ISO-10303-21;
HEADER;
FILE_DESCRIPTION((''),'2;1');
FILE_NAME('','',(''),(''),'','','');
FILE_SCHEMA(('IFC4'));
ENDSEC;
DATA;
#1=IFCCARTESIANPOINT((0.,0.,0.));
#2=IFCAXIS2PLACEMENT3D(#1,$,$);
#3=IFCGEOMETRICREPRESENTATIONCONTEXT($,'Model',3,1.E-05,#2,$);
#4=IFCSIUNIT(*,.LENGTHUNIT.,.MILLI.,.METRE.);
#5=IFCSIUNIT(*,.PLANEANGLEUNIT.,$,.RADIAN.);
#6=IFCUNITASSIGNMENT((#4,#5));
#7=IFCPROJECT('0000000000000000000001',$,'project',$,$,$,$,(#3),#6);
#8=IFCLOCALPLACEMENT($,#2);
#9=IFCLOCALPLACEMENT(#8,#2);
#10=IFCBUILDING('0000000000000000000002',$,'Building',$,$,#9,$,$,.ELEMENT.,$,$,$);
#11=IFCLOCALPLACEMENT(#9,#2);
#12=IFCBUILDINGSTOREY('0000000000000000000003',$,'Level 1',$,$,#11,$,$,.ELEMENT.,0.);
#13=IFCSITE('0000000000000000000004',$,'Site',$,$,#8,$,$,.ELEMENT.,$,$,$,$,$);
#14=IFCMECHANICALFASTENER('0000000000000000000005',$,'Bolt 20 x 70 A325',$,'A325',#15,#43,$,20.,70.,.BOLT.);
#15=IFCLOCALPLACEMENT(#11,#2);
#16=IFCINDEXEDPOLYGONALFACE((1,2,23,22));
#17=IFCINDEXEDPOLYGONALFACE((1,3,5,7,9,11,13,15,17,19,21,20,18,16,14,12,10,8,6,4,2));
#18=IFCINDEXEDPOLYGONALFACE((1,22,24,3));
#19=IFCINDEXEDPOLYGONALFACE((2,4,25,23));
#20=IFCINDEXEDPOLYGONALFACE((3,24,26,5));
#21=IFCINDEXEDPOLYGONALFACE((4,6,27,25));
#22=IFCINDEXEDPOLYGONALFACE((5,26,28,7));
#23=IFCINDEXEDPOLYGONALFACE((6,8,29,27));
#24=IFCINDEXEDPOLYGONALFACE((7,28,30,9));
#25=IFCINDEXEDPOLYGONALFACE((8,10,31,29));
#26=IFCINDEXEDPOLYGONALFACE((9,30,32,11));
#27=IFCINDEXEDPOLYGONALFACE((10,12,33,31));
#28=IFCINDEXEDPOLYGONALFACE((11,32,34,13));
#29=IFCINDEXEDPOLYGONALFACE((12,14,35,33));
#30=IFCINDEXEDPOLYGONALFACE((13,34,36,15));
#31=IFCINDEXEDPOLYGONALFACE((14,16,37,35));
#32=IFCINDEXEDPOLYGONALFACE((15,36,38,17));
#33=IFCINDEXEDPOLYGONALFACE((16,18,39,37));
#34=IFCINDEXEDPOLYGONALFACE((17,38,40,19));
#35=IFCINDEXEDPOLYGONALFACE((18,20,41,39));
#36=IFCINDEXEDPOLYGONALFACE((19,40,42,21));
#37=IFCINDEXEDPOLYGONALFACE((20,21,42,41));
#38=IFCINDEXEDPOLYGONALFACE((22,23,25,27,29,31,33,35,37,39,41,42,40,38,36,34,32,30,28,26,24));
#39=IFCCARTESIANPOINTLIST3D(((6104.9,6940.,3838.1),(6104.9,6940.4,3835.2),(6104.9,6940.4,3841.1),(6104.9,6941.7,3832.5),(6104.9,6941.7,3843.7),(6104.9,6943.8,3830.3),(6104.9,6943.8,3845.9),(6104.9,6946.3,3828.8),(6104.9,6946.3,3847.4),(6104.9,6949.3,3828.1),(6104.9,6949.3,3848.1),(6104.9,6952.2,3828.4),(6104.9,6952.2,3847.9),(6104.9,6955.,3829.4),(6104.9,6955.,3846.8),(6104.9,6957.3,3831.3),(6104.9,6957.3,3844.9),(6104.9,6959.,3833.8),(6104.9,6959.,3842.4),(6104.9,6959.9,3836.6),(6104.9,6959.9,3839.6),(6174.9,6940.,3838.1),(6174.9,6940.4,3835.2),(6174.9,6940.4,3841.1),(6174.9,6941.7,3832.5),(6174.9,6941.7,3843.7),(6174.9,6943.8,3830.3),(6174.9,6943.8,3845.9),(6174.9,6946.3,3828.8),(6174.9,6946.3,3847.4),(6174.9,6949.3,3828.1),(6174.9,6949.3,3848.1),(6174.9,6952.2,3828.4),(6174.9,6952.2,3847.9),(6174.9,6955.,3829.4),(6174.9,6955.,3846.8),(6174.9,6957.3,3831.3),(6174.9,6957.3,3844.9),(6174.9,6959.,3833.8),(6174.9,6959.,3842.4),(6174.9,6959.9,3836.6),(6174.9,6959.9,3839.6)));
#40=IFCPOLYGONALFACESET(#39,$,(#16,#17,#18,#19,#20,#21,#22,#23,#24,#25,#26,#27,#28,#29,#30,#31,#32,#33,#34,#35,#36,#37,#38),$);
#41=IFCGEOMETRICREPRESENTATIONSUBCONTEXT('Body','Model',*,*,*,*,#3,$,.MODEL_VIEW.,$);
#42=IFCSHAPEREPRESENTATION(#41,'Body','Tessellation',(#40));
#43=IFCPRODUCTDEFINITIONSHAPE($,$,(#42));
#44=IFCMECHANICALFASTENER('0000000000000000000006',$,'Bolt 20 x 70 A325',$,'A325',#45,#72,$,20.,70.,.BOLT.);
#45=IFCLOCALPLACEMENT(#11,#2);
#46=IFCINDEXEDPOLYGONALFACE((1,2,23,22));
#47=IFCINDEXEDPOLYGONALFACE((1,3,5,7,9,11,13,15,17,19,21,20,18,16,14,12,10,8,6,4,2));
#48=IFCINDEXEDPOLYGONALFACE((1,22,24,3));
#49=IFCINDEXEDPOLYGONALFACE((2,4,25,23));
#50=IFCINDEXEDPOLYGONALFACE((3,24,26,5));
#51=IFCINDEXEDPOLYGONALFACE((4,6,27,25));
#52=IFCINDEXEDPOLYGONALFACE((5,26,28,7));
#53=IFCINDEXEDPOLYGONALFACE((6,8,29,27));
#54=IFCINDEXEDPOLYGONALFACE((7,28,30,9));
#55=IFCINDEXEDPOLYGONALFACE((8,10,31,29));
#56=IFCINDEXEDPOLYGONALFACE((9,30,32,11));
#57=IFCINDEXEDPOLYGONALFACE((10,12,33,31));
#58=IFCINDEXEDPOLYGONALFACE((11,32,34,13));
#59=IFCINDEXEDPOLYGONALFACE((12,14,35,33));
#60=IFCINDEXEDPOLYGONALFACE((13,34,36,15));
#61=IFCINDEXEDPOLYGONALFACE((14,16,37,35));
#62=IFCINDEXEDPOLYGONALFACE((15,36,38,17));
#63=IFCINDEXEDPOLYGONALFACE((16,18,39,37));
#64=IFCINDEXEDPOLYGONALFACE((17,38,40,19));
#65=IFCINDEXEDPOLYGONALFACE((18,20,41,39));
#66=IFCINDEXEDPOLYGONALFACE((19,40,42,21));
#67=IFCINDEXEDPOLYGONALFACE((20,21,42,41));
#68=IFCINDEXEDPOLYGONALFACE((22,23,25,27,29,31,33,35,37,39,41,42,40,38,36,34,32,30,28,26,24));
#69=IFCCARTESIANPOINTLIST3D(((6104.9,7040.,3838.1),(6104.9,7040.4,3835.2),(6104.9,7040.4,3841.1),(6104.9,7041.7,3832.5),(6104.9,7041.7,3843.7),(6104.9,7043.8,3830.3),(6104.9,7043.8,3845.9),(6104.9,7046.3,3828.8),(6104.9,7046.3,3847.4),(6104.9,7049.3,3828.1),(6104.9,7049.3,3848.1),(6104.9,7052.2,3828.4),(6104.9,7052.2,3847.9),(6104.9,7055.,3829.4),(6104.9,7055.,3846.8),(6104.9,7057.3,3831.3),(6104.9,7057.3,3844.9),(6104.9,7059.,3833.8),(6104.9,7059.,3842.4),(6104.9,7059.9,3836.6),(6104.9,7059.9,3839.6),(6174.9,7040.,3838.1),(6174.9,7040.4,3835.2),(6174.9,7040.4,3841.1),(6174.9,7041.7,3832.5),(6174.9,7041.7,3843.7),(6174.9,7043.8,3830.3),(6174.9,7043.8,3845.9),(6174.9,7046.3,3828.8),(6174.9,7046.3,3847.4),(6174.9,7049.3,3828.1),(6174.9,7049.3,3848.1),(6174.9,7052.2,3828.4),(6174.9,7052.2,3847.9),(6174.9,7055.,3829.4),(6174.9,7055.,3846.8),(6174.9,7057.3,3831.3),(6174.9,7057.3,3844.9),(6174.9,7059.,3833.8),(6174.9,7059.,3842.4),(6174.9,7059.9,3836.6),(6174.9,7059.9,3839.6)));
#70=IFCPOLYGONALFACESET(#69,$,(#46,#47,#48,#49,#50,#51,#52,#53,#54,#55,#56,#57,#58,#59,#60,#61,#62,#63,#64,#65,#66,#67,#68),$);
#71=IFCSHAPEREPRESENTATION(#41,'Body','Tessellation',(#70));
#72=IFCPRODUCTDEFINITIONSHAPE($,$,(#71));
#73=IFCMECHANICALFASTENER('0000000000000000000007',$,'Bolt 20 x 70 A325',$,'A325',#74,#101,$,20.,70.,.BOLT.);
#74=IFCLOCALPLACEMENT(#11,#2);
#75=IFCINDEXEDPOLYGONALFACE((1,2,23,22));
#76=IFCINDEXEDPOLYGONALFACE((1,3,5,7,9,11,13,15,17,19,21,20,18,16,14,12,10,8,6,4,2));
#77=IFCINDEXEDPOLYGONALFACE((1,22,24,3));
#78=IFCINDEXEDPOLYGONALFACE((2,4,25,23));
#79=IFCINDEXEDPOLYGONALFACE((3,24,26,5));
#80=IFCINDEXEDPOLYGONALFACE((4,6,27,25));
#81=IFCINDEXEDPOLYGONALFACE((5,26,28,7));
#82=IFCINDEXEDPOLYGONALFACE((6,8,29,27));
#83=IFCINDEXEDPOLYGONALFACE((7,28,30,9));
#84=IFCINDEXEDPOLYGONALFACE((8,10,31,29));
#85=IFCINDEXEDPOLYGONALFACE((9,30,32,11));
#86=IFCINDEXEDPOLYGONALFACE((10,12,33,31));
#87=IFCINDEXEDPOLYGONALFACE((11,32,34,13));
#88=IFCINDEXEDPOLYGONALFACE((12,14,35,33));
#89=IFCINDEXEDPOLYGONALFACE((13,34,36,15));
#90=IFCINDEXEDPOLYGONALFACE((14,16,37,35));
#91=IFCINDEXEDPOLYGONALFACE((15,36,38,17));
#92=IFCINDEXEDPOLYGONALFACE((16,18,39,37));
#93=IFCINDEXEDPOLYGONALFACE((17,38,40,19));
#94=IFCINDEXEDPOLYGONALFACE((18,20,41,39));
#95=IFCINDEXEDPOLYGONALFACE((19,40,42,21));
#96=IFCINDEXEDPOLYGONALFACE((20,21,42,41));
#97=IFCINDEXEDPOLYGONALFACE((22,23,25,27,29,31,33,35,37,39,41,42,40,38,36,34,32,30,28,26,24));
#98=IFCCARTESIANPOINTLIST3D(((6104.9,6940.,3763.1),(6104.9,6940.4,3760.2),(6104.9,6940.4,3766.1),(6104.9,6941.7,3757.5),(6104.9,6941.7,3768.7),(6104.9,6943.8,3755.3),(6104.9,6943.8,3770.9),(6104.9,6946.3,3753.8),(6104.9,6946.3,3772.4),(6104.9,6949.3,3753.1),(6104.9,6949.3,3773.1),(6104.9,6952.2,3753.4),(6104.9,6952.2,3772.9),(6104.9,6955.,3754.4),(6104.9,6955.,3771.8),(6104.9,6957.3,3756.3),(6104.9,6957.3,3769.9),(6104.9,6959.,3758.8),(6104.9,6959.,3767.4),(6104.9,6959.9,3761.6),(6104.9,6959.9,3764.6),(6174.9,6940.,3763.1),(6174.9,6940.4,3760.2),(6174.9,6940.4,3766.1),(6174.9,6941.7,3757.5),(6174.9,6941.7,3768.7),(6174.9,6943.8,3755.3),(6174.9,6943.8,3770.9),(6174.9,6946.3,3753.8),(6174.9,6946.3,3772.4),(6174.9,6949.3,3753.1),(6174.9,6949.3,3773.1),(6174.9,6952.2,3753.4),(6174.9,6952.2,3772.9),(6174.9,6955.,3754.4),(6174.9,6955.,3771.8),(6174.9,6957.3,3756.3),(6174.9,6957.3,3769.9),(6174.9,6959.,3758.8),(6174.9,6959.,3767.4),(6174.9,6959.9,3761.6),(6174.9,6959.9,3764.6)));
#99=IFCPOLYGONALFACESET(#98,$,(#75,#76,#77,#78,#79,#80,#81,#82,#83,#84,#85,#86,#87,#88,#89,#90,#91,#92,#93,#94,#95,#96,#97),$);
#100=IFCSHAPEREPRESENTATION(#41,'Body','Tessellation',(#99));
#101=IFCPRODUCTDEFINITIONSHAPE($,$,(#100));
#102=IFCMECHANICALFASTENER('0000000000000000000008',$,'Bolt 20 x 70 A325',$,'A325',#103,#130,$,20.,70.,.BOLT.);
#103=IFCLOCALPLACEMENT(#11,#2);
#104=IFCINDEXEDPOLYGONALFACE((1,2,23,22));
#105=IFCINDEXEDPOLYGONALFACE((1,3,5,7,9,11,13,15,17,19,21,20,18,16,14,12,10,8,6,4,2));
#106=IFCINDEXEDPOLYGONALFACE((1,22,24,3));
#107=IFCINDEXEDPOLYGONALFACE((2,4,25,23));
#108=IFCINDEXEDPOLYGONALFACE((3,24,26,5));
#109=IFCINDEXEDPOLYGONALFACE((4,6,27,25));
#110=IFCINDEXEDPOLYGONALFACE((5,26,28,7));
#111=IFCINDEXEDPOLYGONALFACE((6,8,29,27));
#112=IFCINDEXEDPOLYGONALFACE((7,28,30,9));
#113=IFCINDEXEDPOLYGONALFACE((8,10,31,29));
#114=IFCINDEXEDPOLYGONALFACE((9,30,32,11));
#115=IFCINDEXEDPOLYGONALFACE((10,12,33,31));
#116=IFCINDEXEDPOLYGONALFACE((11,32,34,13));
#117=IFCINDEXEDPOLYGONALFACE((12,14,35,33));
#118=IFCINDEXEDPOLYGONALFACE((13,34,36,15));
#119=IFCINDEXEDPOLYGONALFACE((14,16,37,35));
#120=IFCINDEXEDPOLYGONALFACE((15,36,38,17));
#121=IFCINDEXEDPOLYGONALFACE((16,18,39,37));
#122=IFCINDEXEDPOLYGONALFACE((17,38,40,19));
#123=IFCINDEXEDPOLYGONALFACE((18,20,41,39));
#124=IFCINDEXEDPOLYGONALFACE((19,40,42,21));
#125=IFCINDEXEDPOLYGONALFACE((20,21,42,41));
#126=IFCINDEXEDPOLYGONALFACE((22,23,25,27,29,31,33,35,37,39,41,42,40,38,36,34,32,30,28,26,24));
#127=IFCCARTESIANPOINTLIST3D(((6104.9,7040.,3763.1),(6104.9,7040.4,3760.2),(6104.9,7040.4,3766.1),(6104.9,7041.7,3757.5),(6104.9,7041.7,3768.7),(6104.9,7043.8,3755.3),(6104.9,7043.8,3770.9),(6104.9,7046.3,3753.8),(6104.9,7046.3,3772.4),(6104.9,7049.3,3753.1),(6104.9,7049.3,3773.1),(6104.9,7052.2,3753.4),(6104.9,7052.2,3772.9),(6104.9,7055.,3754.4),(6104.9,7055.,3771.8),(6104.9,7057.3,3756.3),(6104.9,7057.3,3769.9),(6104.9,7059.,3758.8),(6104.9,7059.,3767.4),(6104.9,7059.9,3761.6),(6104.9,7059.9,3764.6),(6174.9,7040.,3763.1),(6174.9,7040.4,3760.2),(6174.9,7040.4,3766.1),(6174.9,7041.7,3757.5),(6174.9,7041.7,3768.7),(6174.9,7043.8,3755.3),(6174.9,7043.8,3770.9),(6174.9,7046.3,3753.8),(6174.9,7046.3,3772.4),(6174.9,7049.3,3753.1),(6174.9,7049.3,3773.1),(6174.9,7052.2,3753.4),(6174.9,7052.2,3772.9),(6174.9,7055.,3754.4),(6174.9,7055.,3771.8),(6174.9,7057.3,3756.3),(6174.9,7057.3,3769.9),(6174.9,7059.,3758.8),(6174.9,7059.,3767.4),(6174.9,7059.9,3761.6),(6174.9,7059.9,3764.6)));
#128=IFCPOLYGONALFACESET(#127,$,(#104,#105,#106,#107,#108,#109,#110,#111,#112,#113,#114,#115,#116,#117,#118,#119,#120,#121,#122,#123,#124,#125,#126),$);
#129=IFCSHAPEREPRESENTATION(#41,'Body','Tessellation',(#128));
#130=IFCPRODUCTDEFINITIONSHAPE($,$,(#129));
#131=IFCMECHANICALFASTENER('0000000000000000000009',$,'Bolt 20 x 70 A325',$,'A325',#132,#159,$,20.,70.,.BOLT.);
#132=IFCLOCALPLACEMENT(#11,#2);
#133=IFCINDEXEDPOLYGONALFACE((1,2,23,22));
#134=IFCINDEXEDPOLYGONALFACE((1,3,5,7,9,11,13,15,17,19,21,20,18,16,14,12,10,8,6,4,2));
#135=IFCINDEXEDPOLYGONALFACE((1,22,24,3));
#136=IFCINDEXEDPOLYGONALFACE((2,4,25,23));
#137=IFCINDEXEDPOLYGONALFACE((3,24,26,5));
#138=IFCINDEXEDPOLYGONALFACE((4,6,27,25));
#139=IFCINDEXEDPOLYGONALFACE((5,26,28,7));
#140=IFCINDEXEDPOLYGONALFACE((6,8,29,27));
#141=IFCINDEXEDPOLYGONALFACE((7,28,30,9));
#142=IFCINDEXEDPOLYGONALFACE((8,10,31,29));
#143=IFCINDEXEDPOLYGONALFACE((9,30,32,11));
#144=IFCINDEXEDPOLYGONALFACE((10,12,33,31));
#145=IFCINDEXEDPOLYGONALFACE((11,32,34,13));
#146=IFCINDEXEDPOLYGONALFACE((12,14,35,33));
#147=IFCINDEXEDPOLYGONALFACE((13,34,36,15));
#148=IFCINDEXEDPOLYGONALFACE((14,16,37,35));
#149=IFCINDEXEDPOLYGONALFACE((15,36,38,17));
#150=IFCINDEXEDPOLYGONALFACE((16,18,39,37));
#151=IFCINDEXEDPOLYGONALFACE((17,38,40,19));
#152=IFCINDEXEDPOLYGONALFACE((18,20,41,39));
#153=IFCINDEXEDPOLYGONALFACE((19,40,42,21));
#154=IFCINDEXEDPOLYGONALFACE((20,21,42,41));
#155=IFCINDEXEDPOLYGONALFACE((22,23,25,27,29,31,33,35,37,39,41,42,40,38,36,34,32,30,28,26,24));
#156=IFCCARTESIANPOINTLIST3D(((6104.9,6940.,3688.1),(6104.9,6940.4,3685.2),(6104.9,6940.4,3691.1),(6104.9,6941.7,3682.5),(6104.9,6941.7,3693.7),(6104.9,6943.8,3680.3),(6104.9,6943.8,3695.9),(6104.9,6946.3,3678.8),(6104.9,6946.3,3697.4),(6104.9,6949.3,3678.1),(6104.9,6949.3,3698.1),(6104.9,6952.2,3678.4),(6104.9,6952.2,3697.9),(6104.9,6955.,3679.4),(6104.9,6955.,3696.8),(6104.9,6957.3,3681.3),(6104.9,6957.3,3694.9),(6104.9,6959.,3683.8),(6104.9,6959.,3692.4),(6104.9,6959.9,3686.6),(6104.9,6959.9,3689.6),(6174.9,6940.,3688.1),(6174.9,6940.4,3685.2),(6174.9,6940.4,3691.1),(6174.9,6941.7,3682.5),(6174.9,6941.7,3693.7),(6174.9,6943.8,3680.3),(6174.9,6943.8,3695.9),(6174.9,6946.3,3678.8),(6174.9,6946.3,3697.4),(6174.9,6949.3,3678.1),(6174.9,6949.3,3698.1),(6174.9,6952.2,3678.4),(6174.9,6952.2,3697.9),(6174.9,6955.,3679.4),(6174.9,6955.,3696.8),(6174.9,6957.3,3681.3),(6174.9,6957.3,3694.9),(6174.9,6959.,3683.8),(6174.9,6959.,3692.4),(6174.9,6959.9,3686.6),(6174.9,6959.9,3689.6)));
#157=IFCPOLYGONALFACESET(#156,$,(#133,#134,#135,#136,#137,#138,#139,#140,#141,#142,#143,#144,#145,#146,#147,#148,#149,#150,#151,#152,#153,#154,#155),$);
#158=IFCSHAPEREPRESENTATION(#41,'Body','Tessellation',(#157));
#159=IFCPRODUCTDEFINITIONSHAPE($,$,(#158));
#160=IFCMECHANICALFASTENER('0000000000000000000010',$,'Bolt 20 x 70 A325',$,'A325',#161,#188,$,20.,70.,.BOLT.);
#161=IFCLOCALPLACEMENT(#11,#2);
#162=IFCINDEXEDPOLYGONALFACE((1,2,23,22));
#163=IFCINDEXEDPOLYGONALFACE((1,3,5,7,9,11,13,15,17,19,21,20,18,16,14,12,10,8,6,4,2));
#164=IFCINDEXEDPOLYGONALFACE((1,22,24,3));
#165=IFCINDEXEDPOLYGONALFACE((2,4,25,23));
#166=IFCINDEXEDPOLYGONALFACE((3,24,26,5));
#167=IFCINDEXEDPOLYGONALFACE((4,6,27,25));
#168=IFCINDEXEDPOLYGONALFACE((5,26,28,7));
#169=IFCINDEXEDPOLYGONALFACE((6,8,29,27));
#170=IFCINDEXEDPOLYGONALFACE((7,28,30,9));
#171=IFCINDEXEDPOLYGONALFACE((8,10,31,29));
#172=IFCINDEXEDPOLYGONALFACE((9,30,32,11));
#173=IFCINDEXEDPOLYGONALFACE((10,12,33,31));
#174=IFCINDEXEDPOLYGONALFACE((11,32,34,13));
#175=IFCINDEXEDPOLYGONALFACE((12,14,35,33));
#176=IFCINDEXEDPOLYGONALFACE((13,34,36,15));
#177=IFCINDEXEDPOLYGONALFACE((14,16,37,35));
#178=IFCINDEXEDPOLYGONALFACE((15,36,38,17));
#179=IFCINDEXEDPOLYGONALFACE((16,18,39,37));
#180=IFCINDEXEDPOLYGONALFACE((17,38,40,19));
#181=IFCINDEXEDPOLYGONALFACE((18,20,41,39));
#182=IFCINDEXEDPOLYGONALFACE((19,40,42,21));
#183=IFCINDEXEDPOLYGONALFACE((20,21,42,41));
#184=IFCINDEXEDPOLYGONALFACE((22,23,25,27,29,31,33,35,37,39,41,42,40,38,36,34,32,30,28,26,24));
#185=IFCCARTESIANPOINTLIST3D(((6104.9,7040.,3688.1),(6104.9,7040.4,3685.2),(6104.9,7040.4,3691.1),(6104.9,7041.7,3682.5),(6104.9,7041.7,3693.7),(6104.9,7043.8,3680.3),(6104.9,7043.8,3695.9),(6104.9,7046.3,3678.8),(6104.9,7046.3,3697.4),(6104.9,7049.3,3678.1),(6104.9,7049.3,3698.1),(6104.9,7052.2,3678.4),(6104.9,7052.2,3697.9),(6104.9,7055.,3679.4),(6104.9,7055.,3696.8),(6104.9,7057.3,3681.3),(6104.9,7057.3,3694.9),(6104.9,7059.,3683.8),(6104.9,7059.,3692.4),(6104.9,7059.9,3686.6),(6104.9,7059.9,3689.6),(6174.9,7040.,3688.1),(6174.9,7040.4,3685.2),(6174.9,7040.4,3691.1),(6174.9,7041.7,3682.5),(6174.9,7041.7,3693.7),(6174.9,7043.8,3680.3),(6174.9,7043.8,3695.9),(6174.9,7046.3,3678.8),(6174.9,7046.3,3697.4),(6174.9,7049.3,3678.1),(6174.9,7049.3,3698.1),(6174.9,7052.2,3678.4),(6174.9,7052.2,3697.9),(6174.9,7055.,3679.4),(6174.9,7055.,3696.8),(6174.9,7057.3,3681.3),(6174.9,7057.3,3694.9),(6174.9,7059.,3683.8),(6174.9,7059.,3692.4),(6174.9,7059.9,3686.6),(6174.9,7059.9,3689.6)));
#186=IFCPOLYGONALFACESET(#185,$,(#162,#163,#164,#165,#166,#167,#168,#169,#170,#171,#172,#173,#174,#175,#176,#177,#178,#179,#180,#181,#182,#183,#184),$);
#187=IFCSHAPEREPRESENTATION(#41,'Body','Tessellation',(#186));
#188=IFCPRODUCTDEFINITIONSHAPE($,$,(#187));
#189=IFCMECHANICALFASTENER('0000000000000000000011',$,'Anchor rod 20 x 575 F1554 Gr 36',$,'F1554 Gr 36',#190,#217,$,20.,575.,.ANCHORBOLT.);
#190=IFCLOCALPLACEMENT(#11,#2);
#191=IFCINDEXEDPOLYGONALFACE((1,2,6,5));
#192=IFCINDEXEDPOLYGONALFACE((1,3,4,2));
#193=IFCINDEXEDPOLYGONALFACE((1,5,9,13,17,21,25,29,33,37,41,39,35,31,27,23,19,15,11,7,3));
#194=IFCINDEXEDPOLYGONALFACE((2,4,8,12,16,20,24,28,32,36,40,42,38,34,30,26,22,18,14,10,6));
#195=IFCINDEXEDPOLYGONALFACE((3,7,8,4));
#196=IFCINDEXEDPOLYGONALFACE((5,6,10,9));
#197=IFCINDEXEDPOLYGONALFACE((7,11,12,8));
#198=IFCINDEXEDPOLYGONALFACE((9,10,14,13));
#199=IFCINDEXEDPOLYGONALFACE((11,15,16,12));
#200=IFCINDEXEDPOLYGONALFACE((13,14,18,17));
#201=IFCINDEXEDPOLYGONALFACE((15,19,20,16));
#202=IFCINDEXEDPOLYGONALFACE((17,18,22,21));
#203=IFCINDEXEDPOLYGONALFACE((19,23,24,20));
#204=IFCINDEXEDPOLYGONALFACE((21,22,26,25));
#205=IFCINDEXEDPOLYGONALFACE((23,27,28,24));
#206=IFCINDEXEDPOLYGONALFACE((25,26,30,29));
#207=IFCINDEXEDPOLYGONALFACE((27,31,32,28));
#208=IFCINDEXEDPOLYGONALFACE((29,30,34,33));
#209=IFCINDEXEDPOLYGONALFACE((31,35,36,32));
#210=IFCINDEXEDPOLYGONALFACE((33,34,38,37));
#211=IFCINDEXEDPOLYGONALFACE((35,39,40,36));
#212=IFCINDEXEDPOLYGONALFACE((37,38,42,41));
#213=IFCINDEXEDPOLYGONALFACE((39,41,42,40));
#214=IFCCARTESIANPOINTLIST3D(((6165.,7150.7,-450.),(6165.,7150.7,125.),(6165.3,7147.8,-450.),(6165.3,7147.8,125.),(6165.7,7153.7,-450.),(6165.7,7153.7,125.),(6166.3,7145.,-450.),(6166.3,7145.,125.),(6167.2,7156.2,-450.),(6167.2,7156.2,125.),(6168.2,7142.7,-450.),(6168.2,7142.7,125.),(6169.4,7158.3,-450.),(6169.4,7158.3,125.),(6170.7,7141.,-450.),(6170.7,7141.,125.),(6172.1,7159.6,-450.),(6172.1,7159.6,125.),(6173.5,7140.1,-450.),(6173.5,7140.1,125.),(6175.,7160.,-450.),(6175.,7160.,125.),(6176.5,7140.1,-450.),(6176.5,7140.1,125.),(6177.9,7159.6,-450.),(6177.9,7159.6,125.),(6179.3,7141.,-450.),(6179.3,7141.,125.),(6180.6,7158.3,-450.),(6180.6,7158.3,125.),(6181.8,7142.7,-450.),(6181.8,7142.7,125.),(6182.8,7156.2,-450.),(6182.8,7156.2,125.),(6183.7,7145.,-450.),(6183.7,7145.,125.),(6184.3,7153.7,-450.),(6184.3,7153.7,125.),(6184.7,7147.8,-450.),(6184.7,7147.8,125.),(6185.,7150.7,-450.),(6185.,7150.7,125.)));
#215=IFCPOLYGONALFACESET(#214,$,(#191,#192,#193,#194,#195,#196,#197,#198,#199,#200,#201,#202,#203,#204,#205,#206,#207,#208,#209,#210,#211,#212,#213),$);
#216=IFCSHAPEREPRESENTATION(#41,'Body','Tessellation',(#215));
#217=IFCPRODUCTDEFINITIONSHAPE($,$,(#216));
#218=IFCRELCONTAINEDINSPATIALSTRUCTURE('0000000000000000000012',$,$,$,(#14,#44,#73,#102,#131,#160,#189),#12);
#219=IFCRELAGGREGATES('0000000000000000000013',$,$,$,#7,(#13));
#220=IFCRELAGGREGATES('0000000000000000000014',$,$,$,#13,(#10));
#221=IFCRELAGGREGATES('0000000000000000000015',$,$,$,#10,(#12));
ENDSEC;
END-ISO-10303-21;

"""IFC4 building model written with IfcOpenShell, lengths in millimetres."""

from ifc_helpers import new_model, si_unit, frame, origin, origin_2d, place, context, subcontext, project, spatial, circle, extrude, element, save


model = new_model("IFC4")

# Units and contexts
model_context = context("Model", 3, precision=1e-05, world=origin())
body_context = subcontext(model_context, "Body", "Model", "MODEL_VIEW")
ifc_project = project(units=[si_unit("LENGTHUNIT", "METRE", prefix="MILLI"), si_unit("PLANEANGLEUNIT", "RADIAN")], contexts=[model_context])

# Site, building, storey
site_placement = place(None, origin())
site = spatial("IfcSite", under=ifc_project, at=site_placement, Name="Site", CompositionType="ELEMENT")
building_placement = place(site_placement, origin())
building = spatial("IfcBuilding", under=site, at=building_placement, Name="Building", CompositionType="ELEMENT")
storey_placement = place(building_placement, origin())
storey = spatial("IfcBuildingStorey", under=building, at=storey_placement, Name="Level 1", CompositionType="ELEMENT", Elevation=0.0)

# Mechanical fasteners
for number, where, z_axis, x_axis, name in (
    (1, (6174.9, 6950.0, 3838.1), (-1.0, 0.0, 0.0), (0.0, -1.0, 0.0), "Bolt 20 x 70 A325"),
    (2, (6174.9, 7050.0, 3838.1), (-1.0, 0.0, 0.0), (0.0, -1.0, 0.0), "Bolt 20 x 70 A325"),
    (3, (6174.9, 6950.0, 3763.1), (-1.0, 0.0, 0.0), (0.0, -1.0, 0.0), "Bolt 20 x 70 A325"),
    (4, (6174.9, 7050.0, 3763.1), (-1.0, 0.0, 0.0), (0.0, -1.0, 0.0), "Bolt 20 x 70 A325"),
    (5, (6174.9, 6950.0, 3688.1), (-1.0, 0.0, 0.0), (0.0, -1.0, 0.0), "Bolt 20 x 70 A325"),
    (6, (6174.9, 7050.0, 3688.1), (-1.0, 0.0, 0.0), (0.0, -1.0, 0.0), "Bolt 20 x 70 A325"),
):
    element("IfcMechanicalFastener", number, at=place(storey_placement, frame(where, z_axis=z_axis, x_axis=x_axis)), inside=storey, Name=name, ObjectType="A325", NominalDiameter=20.0, NominalLength=70.0, PredefinedType="BOLT", context=body_context, shape_type="SweptSolid", body=[
        extrude(circle(Radius=10.0, at=origin_2d()), origin(), (0.0, 0.0, 1.0), 70.0),
    ])
mechanical_fastener_placement = place(storey_placement, frame((6175.0, 7150.0, 125.0), z_axis=(0.0, 0.0, -1.0), x_axis=(0.0, 1.0, 0.0)))
element("IfcMechanicalFastener", 7, at=mechanical_fastener_placement, inside=storey, Name="Anchor rod 20 x 575 F1554 Gr 36", ObjectType="F1554 Gr 36", NominalDiameter=20.0, NominalLength=575.0, PredefinedType="ANCHORBOLT", context=body_context, shape_type="SweptSolid", body=[
    extrude(circle(Radius=10.0, at=origin_2d()), origin(), (0.0, 0.0, 1.0), 575.0),
])

save(model, "model.ifc")
